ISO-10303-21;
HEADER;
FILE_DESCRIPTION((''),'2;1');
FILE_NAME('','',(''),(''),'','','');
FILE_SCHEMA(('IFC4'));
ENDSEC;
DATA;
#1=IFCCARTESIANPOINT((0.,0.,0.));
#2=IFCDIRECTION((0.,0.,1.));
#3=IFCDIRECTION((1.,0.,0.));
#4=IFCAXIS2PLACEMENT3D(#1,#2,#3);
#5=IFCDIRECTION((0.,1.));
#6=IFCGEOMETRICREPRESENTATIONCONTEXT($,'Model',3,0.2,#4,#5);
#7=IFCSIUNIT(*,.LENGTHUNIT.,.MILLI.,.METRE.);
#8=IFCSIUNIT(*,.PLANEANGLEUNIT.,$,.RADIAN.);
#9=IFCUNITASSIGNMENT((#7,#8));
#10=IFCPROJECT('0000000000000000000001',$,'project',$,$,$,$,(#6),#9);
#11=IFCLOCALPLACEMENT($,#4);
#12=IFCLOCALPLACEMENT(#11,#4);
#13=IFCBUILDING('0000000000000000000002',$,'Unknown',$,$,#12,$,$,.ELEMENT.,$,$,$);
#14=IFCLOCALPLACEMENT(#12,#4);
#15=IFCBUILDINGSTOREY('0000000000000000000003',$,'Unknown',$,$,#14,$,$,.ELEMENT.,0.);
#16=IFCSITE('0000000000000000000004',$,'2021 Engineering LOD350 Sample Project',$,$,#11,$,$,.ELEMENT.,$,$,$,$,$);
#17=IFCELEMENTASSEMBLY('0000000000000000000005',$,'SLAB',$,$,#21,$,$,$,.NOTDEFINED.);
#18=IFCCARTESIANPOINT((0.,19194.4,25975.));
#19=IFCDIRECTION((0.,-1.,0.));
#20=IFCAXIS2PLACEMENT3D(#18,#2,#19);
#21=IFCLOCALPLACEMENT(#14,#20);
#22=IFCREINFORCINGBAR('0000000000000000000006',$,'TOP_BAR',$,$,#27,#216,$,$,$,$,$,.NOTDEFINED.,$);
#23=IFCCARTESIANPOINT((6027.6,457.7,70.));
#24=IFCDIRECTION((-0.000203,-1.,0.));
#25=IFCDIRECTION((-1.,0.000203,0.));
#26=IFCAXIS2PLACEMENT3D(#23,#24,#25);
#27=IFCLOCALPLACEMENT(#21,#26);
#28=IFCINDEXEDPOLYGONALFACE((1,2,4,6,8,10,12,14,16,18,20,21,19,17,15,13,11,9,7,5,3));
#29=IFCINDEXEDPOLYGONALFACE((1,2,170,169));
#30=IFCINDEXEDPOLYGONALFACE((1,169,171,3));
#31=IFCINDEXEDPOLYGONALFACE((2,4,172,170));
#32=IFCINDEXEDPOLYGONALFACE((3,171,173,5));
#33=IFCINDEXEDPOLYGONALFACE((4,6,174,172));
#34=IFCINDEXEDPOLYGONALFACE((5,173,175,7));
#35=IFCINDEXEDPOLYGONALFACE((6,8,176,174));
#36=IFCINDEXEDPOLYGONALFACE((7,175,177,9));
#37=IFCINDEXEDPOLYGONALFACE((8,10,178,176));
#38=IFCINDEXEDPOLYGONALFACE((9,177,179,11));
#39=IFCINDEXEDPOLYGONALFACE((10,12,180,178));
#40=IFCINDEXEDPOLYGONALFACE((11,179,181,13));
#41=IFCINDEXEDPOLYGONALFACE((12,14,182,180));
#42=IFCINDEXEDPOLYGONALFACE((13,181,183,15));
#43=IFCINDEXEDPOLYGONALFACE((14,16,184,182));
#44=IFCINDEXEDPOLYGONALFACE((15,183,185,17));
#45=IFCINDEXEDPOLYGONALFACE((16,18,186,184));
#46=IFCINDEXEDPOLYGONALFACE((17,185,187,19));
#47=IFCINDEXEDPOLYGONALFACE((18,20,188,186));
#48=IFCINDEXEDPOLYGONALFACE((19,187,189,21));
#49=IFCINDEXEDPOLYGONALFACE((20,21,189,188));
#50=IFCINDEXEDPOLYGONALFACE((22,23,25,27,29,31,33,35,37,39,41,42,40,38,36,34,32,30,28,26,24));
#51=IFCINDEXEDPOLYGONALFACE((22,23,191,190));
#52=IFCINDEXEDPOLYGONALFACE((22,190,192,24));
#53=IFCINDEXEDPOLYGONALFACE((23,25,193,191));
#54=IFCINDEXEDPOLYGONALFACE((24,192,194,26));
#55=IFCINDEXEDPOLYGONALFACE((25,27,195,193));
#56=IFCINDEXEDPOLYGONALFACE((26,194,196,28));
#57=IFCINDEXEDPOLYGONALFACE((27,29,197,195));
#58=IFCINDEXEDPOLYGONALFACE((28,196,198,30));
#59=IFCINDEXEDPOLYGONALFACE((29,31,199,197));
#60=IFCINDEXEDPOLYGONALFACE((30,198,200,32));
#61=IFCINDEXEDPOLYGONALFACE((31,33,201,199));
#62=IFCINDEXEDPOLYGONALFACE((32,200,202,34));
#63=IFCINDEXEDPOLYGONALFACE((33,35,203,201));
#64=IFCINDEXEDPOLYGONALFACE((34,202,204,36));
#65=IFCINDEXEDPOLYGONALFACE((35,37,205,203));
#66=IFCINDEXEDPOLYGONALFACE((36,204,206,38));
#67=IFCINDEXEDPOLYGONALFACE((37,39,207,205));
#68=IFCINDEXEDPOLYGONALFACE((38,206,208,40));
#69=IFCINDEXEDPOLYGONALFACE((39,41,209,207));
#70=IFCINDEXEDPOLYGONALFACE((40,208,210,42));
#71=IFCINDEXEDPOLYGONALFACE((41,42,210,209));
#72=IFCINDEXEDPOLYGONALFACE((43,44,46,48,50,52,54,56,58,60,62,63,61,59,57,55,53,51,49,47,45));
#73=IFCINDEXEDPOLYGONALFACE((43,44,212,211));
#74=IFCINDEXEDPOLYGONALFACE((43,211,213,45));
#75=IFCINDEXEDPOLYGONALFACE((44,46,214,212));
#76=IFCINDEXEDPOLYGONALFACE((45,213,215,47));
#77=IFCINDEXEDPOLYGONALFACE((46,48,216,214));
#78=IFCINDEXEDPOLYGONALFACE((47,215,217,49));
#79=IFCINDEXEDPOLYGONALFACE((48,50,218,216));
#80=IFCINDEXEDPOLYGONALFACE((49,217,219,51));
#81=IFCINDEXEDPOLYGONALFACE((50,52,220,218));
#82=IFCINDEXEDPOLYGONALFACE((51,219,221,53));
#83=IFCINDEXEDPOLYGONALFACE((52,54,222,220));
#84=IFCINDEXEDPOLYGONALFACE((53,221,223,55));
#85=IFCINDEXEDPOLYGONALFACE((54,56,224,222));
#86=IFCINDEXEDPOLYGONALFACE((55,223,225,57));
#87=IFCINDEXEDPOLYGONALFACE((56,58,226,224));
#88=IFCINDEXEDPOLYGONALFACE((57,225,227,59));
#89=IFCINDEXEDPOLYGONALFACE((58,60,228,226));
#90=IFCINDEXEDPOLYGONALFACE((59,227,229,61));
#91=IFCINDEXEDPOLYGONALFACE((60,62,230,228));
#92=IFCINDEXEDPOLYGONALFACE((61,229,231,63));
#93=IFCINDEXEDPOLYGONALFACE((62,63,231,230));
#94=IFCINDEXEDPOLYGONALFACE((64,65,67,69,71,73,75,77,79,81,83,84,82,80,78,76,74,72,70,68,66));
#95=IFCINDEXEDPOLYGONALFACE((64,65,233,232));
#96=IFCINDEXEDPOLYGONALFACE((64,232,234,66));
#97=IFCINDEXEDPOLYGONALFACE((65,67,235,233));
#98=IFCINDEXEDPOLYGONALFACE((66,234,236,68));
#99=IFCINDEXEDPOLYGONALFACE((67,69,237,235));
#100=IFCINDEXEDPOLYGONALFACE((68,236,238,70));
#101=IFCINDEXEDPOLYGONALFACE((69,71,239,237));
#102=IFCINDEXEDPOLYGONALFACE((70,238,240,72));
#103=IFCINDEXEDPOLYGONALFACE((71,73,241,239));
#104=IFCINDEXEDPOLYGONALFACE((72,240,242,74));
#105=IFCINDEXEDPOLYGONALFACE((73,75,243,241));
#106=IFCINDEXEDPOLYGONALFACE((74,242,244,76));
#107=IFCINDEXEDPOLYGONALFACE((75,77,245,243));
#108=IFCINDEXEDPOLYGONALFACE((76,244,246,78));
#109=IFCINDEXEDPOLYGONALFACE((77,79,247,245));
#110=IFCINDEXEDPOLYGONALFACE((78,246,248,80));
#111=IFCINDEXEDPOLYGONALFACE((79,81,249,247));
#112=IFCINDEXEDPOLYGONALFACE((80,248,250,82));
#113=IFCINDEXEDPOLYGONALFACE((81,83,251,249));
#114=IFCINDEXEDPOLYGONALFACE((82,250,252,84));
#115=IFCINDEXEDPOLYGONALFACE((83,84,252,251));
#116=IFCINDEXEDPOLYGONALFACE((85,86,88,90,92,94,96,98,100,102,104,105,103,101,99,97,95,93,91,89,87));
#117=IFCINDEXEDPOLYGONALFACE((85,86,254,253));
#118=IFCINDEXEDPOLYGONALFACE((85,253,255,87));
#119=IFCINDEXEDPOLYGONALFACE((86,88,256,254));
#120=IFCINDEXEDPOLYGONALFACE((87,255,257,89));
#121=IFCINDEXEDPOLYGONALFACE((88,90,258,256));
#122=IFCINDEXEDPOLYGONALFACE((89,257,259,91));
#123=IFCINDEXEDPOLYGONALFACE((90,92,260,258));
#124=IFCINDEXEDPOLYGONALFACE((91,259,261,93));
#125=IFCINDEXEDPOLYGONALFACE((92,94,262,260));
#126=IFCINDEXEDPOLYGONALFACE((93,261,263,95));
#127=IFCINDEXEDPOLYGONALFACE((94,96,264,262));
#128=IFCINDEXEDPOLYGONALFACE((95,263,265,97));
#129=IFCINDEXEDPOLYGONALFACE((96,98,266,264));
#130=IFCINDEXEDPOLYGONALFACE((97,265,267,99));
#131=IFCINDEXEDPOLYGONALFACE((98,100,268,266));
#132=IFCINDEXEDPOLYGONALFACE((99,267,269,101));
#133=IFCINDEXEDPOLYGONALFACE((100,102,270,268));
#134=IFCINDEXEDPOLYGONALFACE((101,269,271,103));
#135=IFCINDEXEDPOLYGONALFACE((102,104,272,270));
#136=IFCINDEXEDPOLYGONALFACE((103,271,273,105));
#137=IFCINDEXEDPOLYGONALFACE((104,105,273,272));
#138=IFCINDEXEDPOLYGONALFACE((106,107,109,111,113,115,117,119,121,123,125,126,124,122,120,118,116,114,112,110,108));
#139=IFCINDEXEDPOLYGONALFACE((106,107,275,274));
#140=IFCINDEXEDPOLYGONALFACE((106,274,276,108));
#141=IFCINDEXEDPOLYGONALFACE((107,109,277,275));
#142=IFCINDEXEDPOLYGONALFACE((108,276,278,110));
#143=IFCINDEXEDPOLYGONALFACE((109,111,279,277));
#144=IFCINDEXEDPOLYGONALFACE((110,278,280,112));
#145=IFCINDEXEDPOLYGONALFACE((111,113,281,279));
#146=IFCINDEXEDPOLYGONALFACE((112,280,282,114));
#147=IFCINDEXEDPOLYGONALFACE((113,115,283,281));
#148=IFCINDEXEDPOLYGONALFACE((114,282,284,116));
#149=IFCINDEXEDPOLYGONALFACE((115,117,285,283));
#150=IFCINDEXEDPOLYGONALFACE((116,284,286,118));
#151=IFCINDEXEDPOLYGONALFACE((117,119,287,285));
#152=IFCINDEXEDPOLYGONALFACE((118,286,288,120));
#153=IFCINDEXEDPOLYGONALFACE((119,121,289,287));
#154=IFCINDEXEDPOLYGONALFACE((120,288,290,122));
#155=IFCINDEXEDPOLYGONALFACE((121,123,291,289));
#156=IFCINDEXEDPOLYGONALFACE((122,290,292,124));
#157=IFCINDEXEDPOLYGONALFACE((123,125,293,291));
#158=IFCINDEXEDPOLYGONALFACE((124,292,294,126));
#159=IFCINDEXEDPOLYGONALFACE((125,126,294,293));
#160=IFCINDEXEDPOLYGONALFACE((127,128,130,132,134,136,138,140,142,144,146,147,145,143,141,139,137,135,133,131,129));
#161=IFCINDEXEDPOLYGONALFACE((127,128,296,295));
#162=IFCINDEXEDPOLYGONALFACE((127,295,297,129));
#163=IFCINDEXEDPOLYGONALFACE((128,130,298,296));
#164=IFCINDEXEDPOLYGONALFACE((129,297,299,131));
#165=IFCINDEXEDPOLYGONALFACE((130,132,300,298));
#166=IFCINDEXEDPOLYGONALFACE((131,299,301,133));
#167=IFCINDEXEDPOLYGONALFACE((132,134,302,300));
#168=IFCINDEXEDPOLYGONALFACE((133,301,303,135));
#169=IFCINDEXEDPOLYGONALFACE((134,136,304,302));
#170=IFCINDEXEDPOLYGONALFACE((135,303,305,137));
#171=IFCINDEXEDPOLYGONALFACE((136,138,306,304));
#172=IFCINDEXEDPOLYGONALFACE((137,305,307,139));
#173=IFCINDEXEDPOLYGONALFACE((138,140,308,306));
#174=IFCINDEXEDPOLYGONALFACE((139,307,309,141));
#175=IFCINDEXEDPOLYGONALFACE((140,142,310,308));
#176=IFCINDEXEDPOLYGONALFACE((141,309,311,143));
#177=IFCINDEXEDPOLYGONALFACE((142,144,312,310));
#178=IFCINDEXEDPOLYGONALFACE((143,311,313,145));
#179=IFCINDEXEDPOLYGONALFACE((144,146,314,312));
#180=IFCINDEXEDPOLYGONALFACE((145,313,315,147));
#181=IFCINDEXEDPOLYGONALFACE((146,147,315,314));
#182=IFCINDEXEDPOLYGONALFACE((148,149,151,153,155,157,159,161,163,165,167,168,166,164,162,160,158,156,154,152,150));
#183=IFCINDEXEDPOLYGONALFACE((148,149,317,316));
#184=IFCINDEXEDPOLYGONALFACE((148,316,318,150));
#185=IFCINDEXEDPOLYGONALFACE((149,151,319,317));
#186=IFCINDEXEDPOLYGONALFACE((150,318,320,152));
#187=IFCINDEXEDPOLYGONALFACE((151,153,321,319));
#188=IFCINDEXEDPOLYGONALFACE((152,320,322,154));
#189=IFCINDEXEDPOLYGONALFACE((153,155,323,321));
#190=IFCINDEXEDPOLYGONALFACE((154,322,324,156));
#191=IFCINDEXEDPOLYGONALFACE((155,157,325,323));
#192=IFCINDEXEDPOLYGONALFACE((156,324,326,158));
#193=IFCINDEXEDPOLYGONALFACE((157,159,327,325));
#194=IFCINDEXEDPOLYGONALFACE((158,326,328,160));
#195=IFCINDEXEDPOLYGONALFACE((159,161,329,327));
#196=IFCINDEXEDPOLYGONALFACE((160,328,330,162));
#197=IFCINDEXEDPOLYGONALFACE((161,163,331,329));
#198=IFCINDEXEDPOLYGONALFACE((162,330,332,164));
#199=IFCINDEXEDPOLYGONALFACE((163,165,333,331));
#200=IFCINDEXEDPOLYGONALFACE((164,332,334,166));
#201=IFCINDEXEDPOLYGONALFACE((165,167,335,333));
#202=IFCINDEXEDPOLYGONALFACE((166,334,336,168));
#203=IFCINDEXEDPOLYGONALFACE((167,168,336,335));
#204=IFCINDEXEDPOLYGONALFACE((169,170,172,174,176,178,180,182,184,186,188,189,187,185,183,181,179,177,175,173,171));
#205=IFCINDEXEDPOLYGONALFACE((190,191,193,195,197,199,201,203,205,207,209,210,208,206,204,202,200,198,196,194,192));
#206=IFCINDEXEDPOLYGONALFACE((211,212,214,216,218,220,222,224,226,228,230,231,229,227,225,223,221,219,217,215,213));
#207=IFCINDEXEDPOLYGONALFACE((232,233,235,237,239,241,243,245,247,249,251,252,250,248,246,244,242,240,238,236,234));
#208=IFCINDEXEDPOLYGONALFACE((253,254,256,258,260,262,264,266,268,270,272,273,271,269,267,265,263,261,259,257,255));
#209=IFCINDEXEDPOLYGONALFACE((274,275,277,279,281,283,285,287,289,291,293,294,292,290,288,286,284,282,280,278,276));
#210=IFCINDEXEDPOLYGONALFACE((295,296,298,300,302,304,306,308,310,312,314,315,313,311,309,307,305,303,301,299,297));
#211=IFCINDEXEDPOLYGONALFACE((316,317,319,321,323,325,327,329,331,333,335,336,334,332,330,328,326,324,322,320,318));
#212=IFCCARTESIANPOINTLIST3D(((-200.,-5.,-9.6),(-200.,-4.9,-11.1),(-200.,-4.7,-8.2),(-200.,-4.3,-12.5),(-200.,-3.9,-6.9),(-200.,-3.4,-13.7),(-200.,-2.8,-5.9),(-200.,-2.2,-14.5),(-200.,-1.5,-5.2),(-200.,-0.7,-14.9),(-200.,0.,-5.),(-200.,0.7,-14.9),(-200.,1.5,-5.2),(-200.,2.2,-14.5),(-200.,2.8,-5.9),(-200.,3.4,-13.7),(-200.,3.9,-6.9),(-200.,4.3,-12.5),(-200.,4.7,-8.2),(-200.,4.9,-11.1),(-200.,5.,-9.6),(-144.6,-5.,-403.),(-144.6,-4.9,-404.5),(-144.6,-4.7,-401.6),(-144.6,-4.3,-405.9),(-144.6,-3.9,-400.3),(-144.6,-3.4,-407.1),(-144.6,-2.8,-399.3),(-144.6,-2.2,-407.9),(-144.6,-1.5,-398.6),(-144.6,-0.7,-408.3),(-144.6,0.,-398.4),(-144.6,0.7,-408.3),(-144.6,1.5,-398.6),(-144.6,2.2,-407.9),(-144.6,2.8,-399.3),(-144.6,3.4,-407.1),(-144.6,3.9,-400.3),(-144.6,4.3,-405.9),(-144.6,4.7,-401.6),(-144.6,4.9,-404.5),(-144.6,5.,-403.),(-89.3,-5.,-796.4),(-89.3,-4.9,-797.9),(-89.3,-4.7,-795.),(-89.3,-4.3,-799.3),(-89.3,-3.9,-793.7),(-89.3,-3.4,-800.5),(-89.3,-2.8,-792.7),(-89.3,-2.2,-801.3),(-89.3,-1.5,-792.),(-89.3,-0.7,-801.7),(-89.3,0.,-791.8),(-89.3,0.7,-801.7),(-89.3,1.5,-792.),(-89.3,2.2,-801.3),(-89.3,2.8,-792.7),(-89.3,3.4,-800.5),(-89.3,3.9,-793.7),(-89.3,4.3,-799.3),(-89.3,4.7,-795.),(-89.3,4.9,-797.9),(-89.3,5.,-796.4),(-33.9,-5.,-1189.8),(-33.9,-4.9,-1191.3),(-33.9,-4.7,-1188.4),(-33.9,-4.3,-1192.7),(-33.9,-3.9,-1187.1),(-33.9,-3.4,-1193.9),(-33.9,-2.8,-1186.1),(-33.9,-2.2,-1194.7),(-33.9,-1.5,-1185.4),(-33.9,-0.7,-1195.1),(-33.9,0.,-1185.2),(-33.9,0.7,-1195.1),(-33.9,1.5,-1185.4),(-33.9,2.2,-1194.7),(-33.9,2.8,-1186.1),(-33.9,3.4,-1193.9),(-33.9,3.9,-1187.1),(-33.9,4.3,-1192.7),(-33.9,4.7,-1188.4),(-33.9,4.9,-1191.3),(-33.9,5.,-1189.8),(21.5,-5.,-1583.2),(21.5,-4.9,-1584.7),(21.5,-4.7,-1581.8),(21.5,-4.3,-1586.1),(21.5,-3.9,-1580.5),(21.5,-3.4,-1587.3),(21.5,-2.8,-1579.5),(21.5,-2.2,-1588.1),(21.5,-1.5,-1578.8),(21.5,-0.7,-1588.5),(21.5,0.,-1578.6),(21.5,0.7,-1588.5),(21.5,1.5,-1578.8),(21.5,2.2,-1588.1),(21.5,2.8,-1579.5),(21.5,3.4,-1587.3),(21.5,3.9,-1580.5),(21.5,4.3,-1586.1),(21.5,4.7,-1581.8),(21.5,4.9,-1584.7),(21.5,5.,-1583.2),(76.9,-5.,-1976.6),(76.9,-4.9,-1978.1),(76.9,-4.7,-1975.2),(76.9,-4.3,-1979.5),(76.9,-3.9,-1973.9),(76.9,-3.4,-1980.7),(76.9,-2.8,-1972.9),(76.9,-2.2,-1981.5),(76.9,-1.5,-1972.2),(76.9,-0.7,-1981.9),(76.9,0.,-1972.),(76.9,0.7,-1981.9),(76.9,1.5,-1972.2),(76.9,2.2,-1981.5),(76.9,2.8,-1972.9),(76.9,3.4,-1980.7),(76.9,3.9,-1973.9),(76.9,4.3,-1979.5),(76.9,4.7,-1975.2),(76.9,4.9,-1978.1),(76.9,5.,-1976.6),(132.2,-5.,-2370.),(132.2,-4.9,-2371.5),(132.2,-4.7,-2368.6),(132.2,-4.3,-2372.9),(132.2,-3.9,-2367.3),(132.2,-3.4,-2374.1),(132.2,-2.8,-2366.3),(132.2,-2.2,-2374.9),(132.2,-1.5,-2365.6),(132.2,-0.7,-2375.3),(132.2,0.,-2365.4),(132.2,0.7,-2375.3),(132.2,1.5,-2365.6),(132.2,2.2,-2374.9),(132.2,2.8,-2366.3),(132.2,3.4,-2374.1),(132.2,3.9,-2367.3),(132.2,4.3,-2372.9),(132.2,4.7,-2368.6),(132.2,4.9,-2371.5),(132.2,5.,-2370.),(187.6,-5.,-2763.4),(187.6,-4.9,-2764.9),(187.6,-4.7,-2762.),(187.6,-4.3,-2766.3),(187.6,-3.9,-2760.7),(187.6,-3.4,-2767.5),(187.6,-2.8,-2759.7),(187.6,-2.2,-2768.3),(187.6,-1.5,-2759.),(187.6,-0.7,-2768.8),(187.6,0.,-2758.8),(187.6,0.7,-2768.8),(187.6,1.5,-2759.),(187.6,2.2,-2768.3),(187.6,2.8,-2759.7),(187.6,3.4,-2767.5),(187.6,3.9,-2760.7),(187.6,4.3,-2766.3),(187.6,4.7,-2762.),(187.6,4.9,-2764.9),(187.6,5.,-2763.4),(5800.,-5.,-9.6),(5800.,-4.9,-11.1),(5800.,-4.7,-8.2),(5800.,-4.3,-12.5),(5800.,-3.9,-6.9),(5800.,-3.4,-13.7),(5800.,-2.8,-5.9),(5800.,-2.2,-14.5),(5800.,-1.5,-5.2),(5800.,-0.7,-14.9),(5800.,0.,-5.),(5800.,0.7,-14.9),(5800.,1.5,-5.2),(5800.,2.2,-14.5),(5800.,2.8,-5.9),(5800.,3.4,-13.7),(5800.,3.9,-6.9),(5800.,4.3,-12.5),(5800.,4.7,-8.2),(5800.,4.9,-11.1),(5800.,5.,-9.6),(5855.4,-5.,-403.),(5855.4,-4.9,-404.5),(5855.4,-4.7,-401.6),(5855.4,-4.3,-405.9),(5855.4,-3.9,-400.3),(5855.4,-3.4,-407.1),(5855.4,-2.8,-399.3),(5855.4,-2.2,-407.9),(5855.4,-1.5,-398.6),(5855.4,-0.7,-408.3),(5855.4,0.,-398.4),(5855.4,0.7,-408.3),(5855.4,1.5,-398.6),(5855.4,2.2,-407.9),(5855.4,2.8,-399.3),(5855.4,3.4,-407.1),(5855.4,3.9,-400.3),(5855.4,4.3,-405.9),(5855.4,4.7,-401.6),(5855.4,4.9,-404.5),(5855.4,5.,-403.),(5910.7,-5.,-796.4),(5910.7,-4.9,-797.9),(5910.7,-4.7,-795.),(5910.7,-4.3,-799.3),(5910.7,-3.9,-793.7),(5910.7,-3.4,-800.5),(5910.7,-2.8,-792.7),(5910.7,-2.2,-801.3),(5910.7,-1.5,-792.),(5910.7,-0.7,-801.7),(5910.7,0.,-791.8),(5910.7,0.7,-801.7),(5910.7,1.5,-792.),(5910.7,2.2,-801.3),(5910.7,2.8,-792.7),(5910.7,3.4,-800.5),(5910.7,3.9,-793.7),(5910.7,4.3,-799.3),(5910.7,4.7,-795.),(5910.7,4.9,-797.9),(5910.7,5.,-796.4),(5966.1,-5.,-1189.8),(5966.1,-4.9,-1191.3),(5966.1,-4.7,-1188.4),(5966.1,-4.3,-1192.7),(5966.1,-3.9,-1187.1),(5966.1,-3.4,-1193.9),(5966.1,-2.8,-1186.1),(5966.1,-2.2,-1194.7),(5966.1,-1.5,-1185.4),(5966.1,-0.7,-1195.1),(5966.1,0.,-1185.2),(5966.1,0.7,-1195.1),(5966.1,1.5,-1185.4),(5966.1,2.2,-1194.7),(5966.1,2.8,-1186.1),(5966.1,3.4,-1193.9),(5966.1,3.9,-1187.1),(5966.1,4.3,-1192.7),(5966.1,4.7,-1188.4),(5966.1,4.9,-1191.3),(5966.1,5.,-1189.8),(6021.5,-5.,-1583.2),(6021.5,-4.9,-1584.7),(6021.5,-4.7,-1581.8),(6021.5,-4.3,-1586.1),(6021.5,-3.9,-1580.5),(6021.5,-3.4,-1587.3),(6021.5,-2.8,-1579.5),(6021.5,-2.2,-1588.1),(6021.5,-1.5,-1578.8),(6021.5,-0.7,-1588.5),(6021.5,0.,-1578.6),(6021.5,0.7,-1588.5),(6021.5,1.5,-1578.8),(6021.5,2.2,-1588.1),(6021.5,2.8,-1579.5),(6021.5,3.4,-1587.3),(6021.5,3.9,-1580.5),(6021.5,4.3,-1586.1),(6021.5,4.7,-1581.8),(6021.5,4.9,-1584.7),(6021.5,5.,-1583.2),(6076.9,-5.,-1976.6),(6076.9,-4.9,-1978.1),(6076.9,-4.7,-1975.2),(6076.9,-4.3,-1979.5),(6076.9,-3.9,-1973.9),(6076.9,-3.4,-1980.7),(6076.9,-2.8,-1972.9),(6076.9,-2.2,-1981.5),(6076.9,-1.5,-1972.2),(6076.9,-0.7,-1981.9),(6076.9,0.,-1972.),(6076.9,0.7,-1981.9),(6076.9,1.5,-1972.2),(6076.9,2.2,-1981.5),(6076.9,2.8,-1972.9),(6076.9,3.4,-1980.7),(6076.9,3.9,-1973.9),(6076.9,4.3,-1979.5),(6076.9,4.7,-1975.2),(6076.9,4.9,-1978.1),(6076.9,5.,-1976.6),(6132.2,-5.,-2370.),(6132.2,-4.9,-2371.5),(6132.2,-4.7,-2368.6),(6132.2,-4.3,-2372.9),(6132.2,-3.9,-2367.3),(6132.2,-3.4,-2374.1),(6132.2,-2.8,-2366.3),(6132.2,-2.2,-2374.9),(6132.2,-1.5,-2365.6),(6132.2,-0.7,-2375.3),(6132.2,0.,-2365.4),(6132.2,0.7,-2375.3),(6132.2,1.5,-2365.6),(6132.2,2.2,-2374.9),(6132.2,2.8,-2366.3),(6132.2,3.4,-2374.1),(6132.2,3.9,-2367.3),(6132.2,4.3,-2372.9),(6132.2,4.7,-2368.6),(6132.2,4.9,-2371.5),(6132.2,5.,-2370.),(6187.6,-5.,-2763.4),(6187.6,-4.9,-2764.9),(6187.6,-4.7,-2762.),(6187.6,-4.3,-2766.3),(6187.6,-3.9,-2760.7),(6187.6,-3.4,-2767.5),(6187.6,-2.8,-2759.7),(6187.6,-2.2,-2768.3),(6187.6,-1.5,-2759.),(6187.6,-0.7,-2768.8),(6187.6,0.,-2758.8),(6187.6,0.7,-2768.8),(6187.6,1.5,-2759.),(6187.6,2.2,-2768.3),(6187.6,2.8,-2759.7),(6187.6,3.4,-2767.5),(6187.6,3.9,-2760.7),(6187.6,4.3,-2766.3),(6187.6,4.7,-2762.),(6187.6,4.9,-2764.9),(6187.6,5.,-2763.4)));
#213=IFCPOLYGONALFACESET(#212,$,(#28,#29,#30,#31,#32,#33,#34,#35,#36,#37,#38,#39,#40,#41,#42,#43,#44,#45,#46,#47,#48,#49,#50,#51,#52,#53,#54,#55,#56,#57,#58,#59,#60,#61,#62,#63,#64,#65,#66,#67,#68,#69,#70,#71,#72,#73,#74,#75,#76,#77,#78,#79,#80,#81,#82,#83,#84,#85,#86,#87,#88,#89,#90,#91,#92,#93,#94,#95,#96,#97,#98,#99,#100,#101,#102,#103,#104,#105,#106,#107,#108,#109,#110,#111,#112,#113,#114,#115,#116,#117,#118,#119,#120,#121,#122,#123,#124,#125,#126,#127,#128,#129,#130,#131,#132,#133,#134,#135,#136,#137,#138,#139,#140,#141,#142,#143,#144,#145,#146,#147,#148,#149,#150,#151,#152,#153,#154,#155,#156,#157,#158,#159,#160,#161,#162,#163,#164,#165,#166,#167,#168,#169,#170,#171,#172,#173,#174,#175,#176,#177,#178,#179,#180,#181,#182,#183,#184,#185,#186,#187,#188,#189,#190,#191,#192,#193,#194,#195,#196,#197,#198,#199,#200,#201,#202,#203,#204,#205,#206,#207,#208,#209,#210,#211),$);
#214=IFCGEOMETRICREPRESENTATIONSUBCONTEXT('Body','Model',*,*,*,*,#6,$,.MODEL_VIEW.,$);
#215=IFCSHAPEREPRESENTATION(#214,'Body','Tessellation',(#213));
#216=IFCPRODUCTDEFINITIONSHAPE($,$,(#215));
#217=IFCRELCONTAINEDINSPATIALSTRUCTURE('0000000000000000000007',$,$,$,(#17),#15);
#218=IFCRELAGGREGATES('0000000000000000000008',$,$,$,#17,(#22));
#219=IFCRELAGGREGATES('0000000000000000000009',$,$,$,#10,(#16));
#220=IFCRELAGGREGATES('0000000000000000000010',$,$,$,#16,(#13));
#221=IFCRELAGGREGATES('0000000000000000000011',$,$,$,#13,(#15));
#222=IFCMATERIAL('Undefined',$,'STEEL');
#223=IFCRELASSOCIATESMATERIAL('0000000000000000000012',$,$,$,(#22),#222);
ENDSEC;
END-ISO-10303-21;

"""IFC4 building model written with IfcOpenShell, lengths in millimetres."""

from ifc_helpers import new_model, entity, si_unit, direction, frame, origin_with_axes, place, context, subcontext, project, spatial, source, transform, mapped, material, element, aggregate, save


model = new_model("IFC4")

# Units and contexts
model_context = context("Model", 3, precision=0.2, world=origin_with_axes(), true_north=direction((0.0, 1.0)))
body_context = subcontext(model_context, "Body", "Model", "MODEL_VIEW")
ifc_project = project(units=[si_unit("LENGTHUNIT", "METRE", prefix="MILLI"), si_unit("PLANEANGLEUNIT", "RADIAN")], contexts=[model_context])

# Site, building, storey
site_placement = place(None, origin_with_axes())
site = spatial("IfcSite", under=ifc_project, at=site_placement, Name="2021 Engineering LOD350 Sample Project", CompositionType="ELEMENT")
building_placement = place(site_placement, origin_with_axes())
building = spatial("IfcBuilding", under=site, at=building_placement, Name="Unknown", CompositionType="ELEMENT")
storey_placement = place(building_placement, origin_with_axes())
storey = spatial("IfcBuildingStorey", under=building, at=storey_placement, Name="Unknown", CompositionType="ELEMENT", Elevation=0.0)

# Element assembly, reinforcing bar
assembly_1_placement = place(storey_placement, frame((0.0, 19194.4, 25975.0), z_axis=(0.0, 0.0, 1.0), x_axis=(0.0, -1.0, 0.0)))
assembly_1 = element("IfcElementAssembly", 1, at=assembly_1_placement, inside=storey, Name="SLAB", PredefinedType="NOTDEFINED")
ifc_material_1 = material(Name="Undefined", Category="STEEL")
shared_shape_1 = source(origin_with_axes(), body_context, "Body", "AdvancedSweptSolid", [
    entity("IfcSweptDiskSolid", entity("IfcIndexedPolyCurve", entity("IfcCartesianPointList3D", [[-200.0, 0.0, -10.0], [5800.0, 0.0, -10.0]]), [entity("IfcLineIndex", [1, 2])]), 5.0),
])
reinforcing_bar_1_placement = place(assembly_1_placement, frame((6027.6, 457.7, 70.0), z_axis=(-0.000203, -1.0, 0.0), x_axis=(-1.0, 0.000203, 0.0)))
reinforcing_bar_1 = element("IfcReinforcingBar", 2, at=reinforcing_bar_1_placement, material=ifc_material_1, Name="TOP_BAR", PredefinedType="NOTDEFINED", context=body_context, shape_type="MappedRepresentation", body=[
    mapped(shared_shape_1, transform((0.0, 0.0, 0.0))),
    mapped(shared_shape_1, transform((55.4, 0.0, -393.4))),
    mapped(shared_shape_1, transform((110.7, 0.0, -786.8))),
    mapped(shared_shape_1, transform((166.1, 0.0, -1180.2))),
    mapped(shared_shape_1, transform((221.5, 0.0, -1573.6))),
    mapped(shared_shape_1, transform((276.9, 0.0, -1967.0))),
    mapped(shared_shape_1, transform((332.2, 0.0, -2360.4))),
    mapped(shared_shape_1, transform((387.6, 0.0, -2753.8))),
])

aggregate(assembly_1, [reinforcing_bar_1])

save(model, "model.ifc")
